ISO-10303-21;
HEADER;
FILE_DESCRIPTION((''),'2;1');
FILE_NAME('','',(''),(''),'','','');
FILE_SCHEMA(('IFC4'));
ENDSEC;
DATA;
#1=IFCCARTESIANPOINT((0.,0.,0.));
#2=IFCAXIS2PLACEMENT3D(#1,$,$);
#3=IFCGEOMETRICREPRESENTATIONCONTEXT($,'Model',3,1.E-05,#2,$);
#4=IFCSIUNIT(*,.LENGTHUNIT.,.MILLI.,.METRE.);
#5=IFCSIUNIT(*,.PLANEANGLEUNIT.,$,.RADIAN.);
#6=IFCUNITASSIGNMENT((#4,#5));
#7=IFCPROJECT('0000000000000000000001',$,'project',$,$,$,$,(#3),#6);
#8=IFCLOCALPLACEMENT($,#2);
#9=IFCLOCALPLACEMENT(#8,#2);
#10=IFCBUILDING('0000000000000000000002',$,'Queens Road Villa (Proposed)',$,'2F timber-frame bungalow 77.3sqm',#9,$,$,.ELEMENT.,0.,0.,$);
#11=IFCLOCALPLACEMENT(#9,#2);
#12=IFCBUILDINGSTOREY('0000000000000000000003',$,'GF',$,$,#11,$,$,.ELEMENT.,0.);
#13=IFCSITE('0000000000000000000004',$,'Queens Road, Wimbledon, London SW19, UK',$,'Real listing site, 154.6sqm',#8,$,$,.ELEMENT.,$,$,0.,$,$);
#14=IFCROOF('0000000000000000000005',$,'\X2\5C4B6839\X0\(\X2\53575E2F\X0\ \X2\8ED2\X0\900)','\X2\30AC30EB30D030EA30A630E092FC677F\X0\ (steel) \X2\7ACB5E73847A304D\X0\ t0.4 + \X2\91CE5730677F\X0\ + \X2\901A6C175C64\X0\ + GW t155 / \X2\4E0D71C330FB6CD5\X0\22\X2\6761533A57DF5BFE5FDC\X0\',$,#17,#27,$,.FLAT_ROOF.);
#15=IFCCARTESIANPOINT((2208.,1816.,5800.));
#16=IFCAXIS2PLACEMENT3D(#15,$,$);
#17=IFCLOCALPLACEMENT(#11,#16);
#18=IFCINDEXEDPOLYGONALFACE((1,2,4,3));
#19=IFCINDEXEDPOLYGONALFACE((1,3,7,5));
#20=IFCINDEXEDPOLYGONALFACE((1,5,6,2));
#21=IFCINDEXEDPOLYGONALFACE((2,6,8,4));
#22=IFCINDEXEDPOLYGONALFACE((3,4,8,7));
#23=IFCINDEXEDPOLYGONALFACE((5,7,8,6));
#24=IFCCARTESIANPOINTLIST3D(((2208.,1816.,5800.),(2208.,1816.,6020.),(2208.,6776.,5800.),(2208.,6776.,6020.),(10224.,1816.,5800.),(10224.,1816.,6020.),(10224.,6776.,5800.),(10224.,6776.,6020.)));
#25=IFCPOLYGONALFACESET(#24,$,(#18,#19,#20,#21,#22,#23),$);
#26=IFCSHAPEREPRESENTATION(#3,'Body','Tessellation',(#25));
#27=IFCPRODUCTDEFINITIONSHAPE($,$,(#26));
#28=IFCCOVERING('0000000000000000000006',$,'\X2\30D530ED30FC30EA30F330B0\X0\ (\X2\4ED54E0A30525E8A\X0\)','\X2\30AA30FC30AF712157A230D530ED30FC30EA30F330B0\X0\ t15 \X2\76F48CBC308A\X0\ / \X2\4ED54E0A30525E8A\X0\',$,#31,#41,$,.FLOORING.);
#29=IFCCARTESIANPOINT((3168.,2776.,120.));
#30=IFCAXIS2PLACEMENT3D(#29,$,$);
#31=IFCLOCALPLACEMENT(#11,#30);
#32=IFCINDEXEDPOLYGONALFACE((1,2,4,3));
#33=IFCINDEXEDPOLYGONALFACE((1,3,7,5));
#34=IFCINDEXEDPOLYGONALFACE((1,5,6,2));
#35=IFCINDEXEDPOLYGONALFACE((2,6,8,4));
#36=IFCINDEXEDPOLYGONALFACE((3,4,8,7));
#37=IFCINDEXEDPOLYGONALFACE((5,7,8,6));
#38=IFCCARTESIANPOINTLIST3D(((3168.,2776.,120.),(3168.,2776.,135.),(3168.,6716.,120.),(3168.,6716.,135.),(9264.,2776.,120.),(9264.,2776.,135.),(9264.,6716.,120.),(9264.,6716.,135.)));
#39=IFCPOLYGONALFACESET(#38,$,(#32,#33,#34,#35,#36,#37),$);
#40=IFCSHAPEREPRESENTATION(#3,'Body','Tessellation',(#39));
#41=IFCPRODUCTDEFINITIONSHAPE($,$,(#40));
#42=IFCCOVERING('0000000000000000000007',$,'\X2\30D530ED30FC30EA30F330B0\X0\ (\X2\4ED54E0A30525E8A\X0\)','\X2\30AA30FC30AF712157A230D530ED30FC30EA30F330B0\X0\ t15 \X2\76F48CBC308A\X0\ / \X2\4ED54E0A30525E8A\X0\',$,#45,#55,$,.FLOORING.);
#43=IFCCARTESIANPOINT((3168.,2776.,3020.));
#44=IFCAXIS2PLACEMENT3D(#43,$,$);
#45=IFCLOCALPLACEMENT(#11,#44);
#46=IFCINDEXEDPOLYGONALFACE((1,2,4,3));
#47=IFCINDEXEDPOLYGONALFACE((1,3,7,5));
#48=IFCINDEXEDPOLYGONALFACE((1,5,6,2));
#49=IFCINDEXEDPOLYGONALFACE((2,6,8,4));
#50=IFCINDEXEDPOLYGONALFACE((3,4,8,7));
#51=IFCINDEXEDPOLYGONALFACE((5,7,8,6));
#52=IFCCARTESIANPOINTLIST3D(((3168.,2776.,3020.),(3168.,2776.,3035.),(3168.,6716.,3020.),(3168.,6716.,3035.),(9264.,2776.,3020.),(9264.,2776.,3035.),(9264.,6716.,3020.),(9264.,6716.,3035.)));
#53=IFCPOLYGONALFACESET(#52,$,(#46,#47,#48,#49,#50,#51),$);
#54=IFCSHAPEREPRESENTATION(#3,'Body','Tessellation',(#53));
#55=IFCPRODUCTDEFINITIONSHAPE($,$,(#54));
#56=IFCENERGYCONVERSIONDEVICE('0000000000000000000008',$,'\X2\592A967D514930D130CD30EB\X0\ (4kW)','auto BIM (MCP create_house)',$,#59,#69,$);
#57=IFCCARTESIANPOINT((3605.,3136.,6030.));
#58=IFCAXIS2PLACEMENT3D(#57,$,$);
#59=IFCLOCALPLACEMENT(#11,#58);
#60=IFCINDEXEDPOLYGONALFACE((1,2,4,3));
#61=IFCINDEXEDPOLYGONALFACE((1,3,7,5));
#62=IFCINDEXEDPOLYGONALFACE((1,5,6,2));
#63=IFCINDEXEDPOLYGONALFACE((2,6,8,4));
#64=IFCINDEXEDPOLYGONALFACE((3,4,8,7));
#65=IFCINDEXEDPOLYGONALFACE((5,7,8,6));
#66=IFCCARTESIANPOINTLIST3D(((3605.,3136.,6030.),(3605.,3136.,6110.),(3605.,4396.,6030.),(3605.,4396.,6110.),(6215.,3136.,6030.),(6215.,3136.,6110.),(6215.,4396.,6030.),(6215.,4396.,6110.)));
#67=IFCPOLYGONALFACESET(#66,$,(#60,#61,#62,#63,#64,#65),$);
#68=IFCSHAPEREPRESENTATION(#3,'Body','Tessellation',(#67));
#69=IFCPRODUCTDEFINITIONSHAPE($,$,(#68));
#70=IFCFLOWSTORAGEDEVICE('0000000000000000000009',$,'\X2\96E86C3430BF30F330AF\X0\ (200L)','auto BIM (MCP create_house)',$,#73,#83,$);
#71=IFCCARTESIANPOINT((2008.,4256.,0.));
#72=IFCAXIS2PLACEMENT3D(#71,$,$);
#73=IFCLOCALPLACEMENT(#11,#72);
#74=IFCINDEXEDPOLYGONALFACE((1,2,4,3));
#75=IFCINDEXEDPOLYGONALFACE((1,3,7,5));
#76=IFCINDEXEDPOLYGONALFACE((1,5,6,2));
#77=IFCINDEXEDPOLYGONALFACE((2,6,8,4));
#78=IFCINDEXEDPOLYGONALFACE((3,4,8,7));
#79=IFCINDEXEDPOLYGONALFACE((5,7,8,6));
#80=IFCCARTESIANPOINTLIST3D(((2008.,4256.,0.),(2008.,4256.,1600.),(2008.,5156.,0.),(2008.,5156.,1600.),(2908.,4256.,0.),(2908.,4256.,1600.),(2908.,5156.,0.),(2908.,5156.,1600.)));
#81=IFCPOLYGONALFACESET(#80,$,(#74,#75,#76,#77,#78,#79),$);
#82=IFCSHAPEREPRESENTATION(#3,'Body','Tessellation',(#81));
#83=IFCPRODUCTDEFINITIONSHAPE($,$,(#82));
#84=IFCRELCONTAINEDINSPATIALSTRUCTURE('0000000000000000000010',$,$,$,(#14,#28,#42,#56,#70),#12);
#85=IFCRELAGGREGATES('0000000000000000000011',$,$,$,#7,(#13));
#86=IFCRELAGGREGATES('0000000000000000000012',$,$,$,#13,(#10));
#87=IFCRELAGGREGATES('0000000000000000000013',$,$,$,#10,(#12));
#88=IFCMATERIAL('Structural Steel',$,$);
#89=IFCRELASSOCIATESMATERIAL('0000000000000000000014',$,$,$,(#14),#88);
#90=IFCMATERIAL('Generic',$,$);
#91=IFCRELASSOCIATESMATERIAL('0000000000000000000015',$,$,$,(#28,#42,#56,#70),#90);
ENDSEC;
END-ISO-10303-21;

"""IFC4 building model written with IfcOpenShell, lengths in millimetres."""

from ifc_helpers import new_model, si_unit, frame, frame_2d, origin, place, context, project, spatial, rectangle, extrude, material, element, save


model = new_model("IFC4")

# Units and contexts
model_context = context("Model", 3, precision=1e-05, world=origin())
ifc_project = project(units=[si_unit("LENGTHUNIT", "METRE", prefix="MILLI"), si_unit("PLANEANGLEUNIT", "RADIAN")], contexts=[model_context])

# Site, building, storey
site_placement = place(None, origin())
site = spatial("IfcSite", under=ifc_project, at=site_placement, Name="Queens Road, Wimbledon, London SW19, UK", ObjectType="Real listing site, 154.6sqm", CompositionType="ELEMENT", RefElevation=0.0)
building_placement = place(site_placement, origin())
building = spatial("IfcBuilding", under=site, at=building_placement, Name="Queens Road Villa (Proposed)", ObjectType="2F timber-frame bungalow 77.3sqm", CompositionType="ELEMENT", ElevationOfRefHeight=0.0, ElevationOfTerrain=0.0)
storey_placement = place(building_placement, origin())
storey = spatial("IfcBuildingStorey", under=building, at=storey_placement, Name="GF", CompositionType="ELEMENT", Elevation=0.0)

# Roof
ifc_material_1 = material(Name="Structural Steel")
for number, where, name in (
    (1, (2208.0, 1816.0, 5800.0), "屋根(南帯 軒900)"),
):
    element("IfcRoof", number, at=place(storey_placement, frame(where)), inside=storey, material=ifc_material_1, Name=name, Description="ガルバリウム鋼板 (steel) 立平葺き t0.4 + 野地板 + 通気層 + GW t155 / 不燃・法22条区域対応", PredefinedType="FLAT_ROOF", context=model_context, shape_type="SweptSolid", body=[
        extrude(rectangle(XDim=8016.0, YDim=4960.0, at=frame_2d((4008.0, 2480.0))), frame((2208.0, 1816.0, 5800.0)), (0.0, 0.0, 1.0), 220.0),
    ])

# Coverings
ifc_material_2 = material(Name="Generic")
covering_1_placement = place(storey_placement, frame((3168.0, 2776.0, 120.0)))
element("IfcCovering", 2, at=covering_1_placement, inside=storey, material=ifc_material_2, Name="フローリング (仕上げ床)", Description="オーク無垢フローリング t15 直貼り / 仕上げ床", PredefinedType="FLOORING", context=model_context, shape_type="SweptSolid", body=[
    extrude(rectangle(XDim=6096.0, YDim=3940.0, at=frame_2d((3048.0, 1970.0))), frame((3168.0, 2776.0, 120.0)), (0.0, 0.0, 1.0), 15.0),
])
covering_2_placement = place(storey_placement, frame((3168.0, 2776.0, 3020.0)))
element("IfcCovering", 3, at=covering_2_placement, inside=storey, material=ifc_material_2, Name="フローリング (仕上げ床)", Description="オーク無垢フローリング t15 直貼り / 仕上げ床", PredefinedType="FLOORING", context=model_context, shape_type="SweptSolid", body=[
    extrude(rectangle(XDim=6096.0, YDim=3940.0, at=frame_2d((3048.0, 1970.0))), frame((3168.0, 2776.0, 3020.0)), (0.0, 0.0, 1.0), 15.0),
])

# Energy conversion device
energy_conversion_device_placement = place(storey_placement, frame((3605.0, 3136.0, 6030.0)))
element("IfcEnergyConversionDevice", 4, at=energy_conversion_device_placement, inside=storey, material=ifc_material_2, Name="太陽光パネル (4kW)", Description="auto BIM (MCP create_house)", context=model_context, shape_type="SweptSolid", body=[
    extrude(rectangle(XDim=2610.0, YDim=1260.0, at=frame_2d((1305.0, 630.0))), frame((3605.0, 3136.0, 6030.0)), (0.0, 0.0, 1.0), 80.0),
])

# Flow storage device
flow_storage_device_placement = place(storey_placement, frame((2008.0, 4256.0, 0.0)))
element("IfcFlowStorageDevice", 5, at=flow_storage_device_placement, inside=storey, material=ifc_material_2, Name="雨水タンク (200L)", Description="auto BIM (MCP create_house)", context=model_context, shape_type="SweptSolid", body=[
    extrude(rectangle(XDim=900.0, YDim=900.0, at=frame_2d((450.0, 450.0))), frame((2008.0, 4256.0, 0.0)), (0.0, 0.0, 1.0), 1600.0),
])

save(model, "model.ifc")
